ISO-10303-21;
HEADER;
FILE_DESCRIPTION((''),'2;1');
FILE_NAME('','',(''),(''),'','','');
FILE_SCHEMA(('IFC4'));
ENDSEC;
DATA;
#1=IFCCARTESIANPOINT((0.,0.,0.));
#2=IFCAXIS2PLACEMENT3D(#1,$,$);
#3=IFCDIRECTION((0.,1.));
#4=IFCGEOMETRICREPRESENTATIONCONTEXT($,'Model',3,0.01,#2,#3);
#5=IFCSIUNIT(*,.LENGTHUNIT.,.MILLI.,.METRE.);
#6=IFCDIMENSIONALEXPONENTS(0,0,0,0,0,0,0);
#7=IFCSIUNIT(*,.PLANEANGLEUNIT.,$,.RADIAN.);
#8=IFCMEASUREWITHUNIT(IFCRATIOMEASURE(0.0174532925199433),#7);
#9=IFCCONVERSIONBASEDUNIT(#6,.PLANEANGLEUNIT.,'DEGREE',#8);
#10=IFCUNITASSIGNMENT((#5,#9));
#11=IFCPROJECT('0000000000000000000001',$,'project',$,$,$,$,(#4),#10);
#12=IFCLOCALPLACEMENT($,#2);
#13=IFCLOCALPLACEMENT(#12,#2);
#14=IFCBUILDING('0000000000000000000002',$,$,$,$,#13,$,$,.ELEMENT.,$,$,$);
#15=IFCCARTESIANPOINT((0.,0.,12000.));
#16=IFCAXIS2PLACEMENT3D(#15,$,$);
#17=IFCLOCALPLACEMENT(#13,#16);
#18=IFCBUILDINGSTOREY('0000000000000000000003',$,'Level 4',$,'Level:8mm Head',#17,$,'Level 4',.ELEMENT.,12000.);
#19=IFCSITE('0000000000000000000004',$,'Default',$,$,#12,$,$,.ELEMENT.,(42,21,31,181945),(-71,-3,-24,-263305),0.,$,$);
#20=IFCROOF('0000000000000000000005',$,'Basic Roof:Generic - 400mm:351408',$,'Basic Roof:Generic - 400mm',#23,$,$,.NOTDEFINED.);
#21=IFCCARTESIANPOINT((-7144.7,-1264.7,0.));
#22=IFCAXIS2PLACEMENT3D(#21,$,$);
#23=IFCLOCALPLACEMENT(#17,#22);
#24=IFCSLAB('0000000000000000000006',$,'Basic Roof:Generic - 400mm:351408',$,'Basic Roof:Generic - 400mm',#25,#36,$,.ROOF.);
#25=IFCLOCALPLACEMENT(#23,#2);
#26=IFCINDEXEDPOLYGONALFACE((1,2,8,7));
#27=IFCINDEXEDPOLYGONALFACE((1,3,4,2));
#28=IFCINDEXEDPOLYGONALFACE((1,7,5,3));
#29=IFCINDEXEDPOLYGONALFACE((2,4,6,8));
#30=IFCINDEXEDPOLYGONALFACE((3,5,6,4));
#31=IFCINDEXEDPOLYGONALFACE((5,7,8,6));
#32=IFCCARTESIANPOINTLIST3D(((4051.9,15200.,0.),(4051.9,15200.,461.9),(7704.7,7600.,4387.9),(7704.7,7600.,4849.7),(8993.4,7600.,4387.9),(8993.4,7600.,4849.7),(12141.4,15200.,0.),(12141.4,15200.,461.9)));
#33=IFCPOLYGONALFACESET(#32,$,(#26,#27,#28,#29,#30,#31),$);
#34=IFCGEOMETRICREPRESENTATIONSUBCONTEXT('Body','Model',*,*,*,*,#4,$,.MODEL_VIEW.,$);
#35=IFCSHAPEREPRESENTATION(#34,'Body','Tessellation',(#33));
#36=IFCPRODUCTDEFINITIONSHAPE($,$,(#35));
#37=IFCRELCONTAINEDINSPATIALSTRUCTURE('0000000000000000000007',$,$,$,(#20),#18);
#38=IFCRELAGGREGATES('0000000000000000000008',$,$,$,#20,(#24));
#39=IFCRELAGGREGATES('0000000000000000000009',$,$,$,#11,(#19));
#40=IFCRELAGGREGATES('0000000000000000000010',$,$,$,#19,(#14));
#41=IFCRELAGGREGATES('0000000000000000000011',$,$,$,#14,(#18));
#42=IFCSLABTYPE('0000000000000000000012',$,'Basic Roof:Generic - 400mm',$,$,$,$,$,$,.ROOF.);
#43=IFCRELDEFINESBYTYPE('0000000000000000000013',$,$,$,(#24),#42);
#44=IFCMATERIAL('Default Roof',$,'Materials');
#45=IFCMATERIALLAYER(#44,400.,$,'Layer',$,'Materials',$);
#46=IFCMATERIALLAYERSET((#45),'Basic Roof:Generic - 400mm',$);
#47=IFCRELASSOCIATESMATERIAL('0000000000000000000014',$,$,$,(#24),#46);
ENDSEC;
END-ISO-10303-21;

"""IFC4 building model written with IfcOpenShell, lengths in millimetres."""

from ifc_helpers import new_model, entity, si_unit, converted_unit, direction, frame, origin, place, context, subcontext, project, spatial, polyline, outline, extrude, material, layer, layer_set, type_object, element, aggregate, save


model = new_model("IFC4")

# Units and contexts
model_context = context("Model", 3, precision=0.01, world=origin(), true_north=direction((0.0, 1.0)))
body_context = subcontext(model_context, "Body", "Model", "MODEL_VIEW")
ifc_project = project(units=[si_unit("LENGTHUNIT", "METRE", prefix="MILLI"), converted_unit("PLANEANGLEUNIT", "DEGREE", entity("IfcRatioMeasure", 0.0174532925199433), si_unit("PLANEANGLEUNIT", "RADIAN"), dimensions=[0, 0, 0, 0, 0, 0, 0])], contexts=[model_context])

# Site, building, storey
site_placement = place(None, origin())
site = spatial("IfcSite", under=ifc_project, at=site_placement, Name="Default", CompositionType="ELEMENT", RefLatitude=(42, 21, 31, 181945), RefLongitude=(-71, -3, -24, -263305), RefElevation=0.0)
building_placement = place(site_placement, origin())
building = spatial("IfcBuilding", under=site, at=building_placement, CompositionType="ELEMENT")
storey_placement = place(building_placement, frame((0.0, 0.0, 12000.0)))
storey = spatial("IfcBuildingStorey", under=building, at=storey_placement, Name="Level 4", ObjectType="Level:8mm Head", LongName="Level 4", CompositionType="ELEMENT", Elevation=12000.0)

# Roof, slab
roof_placement = place(storey_placement, frame((-7144.7, -1264.7, 0.0)))
roof = element("IfcRoof", 1, at=roof_placement, inside=storey, Name="Basic Roof:Generic - 400mm:351408", ObjectType="Basic Roof:Generic - 400mm", PredefinedType="NOTDEFINED")
ifc_material = material(Name="Default Roof", Category="Materials")
ifc_layer = layer(ifc_material, 400.0, Name="Layer", Category="Materials")
ifc_layer_set = layer_set([ifc_layer], Name="Basic Roof:Generic - 400mm")
slab_type_1 = type_object("IfcSlabType", Name="Basic Roof:Generic - 400mm", PredefinedType="ROOF")
slab_1_placement = place(roof_placement, origin())
slab_1 = element("IfcSlab", 2, at=slab_1_placement, type_object=slab_type_1, material=ifc_layer_set, Name="Basic Roof:Generic - 400mm:351408", ObjectType="Basic Roof:Generic - 400mm", PredefinedType="ROOF", context=body_context, shape_type="SweptSolid", body=[
    extrude(outline(polyline([(-4044.7, 4387.9), (-392.0, -4387.9), (896.7, -4387.9), (4044.7, 4387.9), (-4044.7, 4387.9)])), frame((8096.7, 11400.0, 2193.9), z_axis=(0.0, 0.5, 0.866025), x_axis=(1.0, 0.0, 0.0)), (0.0, -0.5, 0.866025), 461.9),
])
aggregate(roof, [slab_1])

save(model, "model.ifc")
